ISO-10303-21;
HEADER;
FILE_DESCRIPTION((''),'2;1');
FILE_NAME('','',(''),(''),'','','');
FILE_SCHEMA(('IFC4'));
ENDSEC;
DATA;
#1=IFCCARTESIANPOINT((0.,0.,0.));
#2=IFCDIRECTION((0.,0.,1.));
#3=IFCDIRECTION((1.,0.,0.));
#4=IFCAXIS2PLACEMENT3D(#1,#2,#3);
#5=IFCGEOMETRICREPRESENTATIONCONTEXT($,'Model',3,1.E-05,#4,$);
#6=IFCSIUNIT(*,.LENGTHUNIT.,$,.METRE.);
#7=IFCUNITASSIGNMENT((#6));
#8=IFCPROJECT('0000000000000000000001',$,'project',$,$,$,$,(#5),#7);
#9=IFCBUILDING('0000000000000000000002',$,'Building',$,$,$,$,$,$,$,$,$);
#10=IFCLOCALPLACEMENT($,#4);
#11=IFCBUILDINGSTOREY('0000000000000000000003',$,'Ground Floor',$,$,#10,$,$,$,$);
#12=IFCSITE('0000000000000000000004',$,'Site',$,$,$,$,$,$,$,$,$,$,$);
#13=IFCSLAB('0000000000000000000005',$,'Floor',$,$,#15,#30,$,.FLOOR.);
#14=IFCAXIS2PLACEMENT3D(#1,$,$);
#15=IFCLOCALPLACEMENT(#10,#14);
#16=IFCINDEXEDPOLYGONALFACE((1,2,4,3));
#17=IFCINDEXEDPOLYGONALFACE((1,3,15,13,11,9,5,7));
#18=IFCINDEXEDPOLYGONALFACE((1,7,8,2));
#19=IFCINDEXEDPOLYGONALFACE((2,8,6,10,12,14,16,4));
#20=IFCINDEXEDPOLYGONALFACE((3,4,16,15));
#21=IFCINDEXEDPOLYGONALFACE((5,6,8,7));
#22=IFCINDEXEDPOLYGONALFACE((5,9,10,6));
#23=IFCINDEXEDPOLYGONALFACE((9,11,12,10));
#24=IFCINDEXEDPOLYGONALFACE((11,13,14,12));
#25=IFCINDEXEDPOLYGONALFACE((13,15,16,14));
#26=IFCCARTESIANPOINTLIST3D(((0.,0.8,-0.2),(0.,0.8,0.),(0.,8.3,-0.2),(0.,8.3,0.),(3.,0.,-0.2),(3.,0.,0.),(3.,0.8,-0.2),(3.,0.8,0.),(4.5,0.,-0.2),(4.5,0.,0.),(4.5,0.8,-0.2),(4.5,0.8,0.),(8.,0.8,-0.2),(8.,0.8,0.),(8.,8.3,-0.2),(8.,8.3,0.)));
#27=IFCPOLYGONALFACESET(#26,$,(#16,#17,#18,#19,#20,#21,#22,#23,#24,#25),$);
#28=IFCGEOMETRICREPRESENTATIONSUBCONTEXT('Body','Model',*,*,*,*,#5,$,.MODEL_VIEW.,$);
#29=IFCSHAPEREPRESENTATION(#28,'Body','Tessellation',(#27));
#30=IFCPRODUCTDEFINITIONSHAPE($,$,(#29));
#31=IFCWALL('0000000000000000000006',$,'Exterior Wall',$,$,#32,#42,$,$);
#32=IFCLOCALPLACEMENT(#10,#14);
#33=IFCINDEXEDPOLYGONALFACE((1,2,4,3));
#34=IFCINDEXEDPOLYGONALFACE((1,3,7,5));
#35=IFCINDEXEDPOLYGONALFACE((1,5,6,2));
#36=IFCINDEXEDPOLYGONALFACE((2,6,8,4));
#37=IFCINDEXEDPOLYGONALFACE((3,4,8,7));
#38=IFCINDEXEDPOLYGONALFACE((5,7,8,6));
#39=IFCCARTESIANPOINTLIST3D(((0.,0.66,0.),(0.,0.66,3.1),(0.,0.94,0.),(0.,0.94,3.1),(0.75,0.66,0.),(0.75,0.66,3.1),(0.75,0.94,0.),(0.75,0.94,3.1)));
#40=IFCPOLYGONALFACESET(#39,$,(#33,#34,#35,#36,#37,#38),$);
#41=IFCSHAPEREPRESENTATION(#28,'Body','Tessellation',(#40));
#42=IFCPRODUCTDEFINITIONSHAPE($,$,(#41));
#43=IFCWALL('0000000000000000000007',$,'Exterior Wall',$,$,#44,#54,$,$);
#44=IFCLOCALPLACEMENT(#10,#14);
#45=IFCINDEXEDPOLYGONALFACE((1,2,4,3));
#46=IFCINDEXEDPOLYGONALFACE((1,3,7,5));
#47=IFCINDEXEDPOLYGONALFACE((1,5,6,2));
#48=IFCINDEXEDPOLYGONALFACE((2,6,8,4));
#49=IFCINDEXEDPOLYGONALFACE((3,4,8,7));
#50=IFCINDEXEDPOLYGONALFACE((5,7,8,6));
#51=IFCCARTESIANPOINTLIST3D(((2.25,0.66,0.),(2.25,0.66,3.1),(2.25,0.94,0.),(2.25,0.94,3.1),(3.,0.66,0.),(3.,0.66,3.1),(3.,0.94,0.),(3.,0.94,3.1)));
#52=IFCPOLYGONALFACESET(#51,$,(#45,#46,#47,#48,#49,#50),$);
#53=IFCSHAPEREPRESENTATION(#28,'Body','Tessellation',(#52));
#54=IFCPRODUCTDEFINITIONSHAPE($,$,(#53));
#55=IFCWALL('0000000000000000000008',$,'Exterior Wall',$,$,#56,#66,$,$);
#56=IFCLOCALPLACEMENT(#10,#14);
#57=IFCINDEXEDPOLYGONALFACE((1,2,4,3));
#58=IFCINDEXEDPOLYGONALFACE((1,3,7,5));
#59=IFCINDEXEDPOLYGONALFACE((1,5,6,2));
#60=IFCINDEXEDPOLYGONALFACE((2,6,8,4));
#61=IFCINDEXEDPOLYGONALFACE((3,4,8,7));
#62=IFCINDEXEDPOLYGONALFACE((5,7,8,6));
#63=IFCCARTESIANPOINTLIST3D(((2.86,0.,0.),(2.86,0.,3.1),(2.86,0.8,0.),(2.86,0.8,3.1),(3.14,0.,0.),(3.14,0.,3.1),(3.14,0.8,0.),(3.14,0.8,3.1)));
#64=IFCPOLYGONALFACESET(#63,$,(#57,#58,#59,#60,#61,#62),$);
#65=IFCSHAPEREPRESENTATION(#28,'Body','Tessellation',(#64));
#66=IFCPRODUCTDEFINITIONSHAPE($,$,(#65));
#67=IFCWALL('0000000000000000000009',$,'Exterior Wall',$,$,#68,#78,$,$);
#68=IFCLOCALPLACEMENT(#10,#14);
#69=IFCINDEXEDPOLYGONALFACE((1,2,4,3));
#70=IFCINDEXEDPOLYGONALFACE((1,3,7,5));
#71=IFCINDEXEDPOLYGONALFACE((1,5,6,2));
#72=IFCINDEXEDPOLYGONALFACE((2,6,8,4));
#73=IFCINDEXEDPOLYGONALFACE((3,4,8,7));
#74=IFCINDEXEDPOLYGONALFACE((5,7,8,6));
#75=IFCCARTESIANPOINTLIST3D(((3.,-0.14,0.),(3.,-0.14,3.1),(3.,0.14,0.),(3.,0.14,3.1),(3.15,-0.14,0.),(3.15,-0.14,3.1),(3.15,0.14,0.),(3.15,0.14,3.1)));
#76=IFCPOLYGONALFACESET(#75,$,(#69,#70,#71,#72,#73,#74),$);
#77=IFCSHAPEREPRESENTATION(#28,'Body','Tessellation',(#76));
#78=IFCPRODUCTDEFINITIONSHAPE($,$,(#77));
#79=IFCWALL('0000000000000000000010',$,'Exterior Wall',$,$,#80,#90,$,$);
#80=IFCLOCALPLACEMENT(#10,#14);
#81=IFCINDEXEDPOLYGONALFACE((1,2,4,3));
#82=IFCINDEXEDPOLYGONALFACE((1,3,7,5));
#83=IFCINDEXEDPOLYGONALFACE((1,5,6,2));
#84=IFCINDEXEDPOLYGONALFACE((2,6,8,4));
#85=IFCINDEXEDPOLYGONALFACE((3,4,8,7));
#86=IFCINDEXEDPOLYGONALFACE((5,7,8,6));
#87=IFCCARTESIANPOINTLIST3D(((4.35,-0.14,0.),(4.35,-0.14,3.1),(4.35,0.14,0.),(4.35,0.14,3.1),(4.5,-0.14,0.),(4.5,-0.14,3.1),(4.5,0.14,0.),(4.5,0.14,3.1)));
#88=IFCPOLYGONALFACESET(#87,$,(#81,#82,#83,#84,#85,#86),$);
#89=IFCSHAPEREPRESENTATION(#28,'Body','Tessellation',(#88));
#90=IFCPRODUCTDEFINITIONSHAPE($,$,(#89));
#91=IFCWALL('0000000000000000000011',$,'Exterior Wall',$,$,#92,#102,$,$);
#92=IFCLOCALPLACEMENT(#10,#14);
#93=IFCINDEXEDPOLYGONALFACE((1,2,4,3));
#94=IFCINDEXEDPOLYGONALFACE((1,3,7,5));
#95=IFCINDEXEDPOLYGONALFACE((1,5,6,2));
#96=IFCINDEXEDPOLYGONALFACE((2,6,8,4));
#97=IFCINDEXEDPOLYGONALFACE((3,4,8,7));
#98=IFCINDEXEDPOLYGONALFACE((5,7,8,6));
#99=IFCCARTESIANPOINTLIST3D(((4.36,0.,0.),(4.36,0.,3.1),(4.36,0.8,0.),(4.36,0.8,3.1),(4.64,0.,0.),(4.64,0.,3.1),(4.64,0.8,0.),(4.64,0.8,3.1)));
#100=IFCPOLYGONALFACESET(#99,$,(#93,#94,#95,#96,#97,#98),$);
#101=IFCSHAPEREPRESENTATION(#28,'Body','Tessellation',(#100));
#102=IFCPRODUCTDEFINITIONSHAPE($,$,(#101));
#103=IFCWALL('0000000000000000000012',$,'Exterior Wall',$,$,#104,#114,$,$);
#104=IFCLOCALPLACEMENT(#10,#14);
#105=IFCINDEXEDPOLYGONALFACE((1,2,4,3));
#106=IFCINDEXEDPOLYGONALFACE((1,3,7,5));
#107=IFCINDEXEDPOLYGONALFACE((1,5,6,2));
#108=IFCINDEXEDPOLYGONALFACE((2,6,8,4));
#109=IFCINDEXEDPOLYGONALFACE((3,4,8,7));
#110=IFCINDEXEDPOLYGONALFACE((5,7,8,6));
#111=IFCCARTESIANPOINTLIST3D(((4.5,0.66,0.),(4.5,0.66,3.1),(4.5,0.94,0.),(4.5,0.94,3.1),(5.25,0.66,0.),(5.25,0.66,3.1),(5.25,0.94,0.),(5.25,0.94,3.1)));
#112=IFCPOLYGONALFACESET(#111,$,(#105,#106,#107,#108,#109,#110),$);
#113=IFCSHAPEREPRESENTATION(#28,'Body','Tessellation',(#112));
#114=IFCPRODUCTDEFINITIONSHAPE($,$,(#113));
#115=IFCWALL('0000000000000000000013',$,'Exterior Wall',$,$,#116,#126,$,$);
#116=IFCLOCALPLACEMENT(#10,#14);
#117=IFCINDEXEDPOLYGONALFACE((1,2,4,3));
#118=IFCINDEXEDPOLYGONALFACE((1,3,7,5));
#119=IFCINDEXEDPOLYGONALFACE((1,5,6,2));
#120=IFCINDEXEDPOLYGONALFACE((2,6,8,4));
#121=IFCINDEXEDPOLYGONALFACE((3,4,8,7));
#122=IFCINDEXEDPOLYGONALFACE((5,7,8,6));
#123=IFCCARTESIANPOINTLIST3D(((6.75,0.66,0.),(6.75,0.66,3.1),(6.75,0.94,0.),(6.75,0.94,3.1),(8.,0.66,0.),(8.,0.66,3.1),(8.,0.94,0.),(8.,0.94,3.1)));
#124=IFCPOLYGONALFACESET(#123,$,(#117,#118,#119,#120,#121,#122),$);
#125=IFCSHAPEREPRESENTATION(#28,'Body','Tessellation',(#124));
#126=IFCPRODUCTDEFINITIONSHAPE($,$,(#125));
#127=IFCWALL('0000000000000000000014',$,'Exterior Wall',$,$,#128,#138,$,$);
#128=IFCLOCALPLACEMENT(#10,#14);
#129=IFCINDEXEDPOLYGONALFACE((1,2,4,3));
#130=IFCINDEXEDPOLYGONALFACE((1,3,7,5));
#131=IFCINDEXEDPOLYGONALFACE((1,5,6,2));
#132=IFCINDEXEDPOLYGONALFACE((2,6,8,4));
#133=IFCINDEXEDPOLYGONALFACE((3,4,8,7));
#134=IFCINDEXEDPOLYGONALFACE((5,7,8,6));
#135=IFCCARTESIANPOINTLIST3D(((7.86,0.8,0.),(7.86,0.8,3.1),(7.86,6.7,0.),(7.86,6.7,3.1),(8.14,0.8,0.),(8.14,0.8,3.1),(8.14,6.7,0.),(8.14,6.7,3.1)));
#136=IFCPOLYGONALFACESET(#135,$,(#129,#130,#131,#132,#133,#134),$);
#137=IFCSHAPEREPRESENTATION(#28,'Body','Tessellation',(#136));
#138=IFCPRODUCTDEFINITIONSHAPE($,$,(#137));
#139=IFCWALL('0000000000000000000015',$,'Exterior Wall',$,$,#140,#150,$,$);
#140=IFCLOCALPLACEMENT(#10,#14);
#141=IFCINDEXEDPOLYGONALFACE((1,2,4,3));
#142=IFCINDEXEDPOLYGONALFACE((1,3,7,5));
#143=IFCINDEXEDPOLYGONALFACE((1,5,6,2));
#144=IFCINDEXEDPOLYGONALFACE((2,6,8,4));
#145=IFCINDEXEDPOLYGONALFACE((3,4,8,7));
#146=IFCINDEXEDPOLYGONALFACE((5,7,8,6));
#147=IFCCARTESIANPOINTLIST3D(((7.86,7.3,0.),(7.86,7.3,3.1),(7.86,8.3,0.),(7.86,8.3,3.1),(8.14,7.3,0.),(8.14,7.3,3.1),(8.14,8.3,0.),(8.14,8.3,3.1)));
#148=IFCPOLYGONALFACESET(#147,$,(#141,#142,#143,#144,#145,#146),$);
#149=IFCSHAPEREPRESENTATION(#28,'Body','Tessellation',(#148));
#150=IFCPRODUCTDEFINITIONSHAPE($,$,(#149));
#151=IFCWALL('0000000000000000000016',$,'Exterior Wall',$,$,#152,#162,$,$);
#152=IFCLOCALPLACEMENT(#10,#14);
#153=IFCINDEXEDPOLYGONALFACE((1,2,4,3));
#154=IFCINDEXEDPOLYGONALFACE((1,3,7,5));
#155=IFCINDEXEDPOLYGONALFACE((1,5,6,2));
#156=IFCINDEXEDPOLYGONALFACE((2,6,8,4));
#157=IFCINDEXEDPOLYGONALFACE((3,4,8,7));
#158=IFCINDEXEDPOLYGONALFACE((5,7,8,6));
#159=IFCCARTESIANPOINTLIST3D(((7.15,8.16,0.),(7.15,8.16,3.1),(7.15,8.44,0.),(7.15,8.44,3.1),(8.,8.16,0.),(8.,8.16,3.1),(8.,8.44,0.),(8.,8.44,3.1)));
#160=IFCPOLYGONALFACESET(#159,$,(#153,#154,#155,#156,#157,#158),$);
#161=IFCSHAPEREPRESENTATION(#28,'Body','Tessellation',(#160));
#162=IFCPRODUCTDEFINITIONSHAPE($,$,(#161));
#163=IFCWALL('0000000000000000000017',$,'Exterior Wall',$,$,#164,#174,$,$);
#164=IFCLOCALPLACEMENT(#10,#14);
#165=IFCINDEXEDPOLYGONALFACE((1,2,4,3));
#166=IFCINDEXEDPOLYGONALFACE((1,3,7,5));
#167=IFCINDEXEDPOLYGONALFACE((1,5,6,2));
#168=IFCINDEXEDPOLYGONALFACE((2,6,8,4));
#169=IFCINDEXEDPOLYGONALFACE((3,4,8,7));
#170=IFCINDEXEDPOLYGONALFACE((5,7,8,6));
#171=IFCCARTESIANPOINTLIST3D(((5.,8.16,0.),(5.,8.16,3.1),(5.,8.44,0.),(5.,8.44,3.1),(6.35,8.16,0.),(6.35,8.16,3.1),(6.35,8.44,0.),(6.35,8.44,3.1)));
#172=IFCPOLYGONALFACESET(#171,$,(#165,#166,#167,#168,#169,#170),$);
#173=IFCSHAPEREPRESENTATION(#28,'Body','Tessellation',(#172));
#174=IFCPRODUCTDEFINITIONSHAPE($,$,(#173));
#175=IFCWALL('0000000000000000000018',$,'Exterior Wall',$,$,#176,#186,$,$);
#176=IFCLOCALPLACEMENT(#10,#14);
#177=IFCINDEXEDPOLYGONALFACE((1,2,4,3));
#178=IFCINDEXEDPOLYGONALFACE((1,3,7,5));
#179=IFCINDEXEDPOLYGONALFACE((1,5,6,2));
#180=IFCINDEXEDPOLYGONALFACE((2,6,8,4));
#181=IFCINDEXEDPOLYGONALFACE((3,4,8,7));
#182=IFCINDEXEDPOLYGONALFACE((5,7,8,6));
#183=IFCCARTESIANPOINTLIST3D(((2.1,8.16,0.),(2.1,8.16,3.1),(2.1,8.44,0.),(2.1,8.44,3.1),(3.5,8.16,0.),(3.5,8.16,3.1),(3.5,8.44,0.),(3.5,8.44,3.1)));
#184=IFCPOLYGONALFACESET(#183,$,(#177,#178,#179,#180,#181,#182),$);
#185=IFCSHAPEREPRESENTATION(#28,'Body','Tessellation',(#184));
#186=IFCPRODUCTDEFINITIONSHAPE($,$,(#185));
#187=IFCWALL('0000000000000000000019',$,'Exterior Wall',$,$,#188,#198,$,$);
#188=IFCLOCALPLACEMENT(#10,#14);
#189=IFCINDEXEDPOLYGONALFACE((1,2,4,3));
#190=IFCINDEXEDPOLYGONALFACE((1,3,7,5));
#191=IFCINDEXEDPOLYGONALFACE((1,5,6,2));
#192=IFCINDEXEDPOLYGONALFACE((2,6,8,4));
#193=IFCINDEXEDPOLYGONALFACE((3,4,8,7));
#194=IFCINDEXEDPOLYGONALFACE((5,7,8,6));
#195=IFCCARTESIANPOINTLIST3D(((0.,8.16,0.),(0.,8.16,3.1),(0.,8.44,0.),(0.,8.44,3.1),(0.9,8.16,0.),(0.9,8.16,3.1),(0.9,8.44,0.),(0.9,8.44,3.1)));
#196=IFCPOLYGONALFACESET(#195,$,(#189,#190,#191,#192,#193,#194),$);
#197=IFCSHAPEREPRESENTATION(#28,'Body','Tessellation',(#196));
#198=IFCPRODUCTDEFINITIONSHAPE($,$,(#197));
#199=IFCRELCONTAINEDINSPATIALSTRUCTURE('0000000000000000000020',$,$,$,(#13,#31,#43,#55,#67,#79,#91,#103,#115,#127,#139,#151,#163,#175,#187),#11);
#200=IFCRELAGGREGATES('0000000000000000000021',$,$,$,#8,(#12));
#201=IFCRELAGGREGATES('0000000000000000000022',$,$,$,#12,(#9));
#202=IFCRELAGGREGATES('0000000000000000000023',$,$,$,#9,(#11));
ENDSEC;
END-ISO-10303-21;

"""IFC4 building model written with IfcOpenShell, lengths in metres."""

from ifc_helpers import new_model, si_unit, frame, origin_with_axes, place, context, subcontext, project, spatial, indexed_curve, outline, extrude, element, save


model = new_model("IFC4")

# Units and contexts
model_context = context("Model", 3, precision=1e-05, world=origin_with_axes())
body_context = subcontext(model_context, "Body", "Model", "MODEL_VIEW")
ifc_project = project(units=[si_unit("LENGTHUNIT", "METRE")], contexts=[model_context])

# Site, building, storey
site = spatial("IfcSite", under=ifc_project, Name="Site")
building = spatial("IfcBuilding", under=site, Name="Building")
storey_placement = place(None, origin_with_axes())
storey = spatial("IfcBuildingStorey", under=building, at=storey_placement, Name="Ground Floor")

# Slab
slab_placement = place(storey_placement, frame((0.0, 0.0, -0.2), z_axis=(0.0, 0.0, 1.0), x_axis=(1.0, 0.0, 0.0)))
element("IfcSlab", 1, at=slab_placement, inside=storey, Name="Floor", PredefinedType="FLOOR", context=body_context, shape_type="SweptSolid", body=[
    extrude(outline(indexed_curve([(0.0, 0.8), (3.0, 0.8), (3.0, 0.0), (4.5, 0.0), (4.5, 0.8), (8.0, 0.8), (8.0, 8.3), (0.0, 8.3)])), None, (0.0, 0.0, 1.0), 0.2),
])

# Walls
for number, where, z_axis, x_axis, name in (
    (2, (0.0, 0.8, 0.0), (0.0, 0.0, 1.0), (1.0, 0.0, 0.0), "Exterior Wall"),
    (3, (2.25, 0.8, 0.0), (0.0, 0.0, 1.0), (1.0, 0.0, 0.0), "Exterior Wall"),
):
    element("IfcWall", number, at=place(storey_placement, frame(where, z_axis=z_axis, x_axis=x_axis)), inside=storey, Name=name, context=body_context, shape_type="SweptSolid", body=[
        extrude(outline(indexed_curve([(0.0, 0.0), (0.0, 0.28), (0.75, 0.28), (0.75, 0.0), (0.0, 0.0)], self_intersect=False)), frame((0.0, -0.14, 0.0), z_axis=(0.0, 0.0, 1.0), x_axis=(1.0, 0.0, 0.0)), (0.0, 0.0, 1.0), 3.1),
    ])
wall_1_placement = place(storey_placement, frame((3.0, 0.8, 0.0), z_axis=(0.0, 0.0, 1.0), x_axis=(0.0, -1.0, 0.0)))
element("IfcWall", 4, at=wall_1_placement, inside=storey, Name="Exterior Wall", context=body_context, shape_type="SweptSolid", body=[
    extrude(outline(indexed_curve([(0.0, 0.0), (0.0, 0.28), (0.8, 0.28), (0.8, 0.0), (0.0, 0.0)], self_intersect=False)), frame((0.0, -0.14, 0.0), z_axis=(0.0, 0.0, 1.0), x_axis=(1.0, 0.0, 0.0)), (0.0, 0.0, 1.0), 3.1),
])
wall_2_placement = place(storey_placement, frame((3.0, 0.0, 0.0), z_axis=(0.0, 0.0, 1.0), x_axis=(1.0, 0.0, 0.0)))
element("IfcWall", 5, at=wall_2_placement, inside=storey, Name="Exterior Wall", context=body_context, shape_type="SweptSolid", body=[
    extrude(outline(indexed_curve([(0.0, 0.0), (0.0, 0.28), (0.15, 0.28), (0.15, 0.0), (0.0, 0.0)], self_intersect=False)), frame((0.0, -0.14, 0.0), z_axis=(0.0, 0.0, 1.0), x_axis=(1.0, 0.0, 0.0)), (0.0, 0.0, 1.0), 3.1),
])
wall_3_placement = place(storey_placement, frame((4.35, 0.0, 0.0), z_axis=(0.0, 0.0, 1.0), x_axis=(1.0, 0.0, 0.0)))
element("IfcWall", 6, at=wall_3_placement, inside=storey, Name="Exterior Wall", context=body_context, shape_type="SweptSolid", body=[
    extrude(outline(indexed_curve([(0.0, 0.0), (0.0, 0.28), (0.15, 0.28), (0.15, 0.0), (0.0, 0.0)], self_intersect=False)), frame((0.0, -0.14, 0.0), z_axis=(0.0, 0.0, 1.0), x_axis=(1.0, 0.0, 0.0)), (0.0, 0.0, 1.0), 3.1),
])
wall_4_placement = place(storey_placement, frame((4.5, 0.0, 0.0), z_axis=(0.0, 0.0, 1.0), x_axis=(0.0, 1.0, 0.0)))
element("IfcWall", 7, at=wall_4_placement, inside=storey, Name="Exterior Wall", context=body_context, shape_type="SweptSolid", body=[
    extrude(outline(indexed_curve([(0.0, 0.0), (0.0, 0.28), (0.8, 0.28), (0.8, 0.0), (0.0, 0.0)], self_intersect=False)), frame((0.0, -0.14, 0.0), z_axis=(0.0, 0.0, 1.0), x_axis=(1.0, 0.0, 0.0)), (0.0, 0.0, 1.0), 3.1),
])
wall_5_placement = place(storey_placement, frame((4.5, 0.8, 0.0), z_axis=(0.0, 0.0, 1.0), x_axis=(1.0, 0.0, 0.0)))
element("IfcWall", 8, at=wall_5_placement, inside=storey, Name="Exterior Wall", context=body_context, shape_type="SweptSolid", body=[
    extrude(outline(indexed_curve([(0.0, 0.0), (0.0, 0.28), (0.75, 0.28), (0.75, 0.0), (0.0, 0.0)], self_intersect=False)), frame((0.0, -0.14, 0.0), z_axis=(0.0, 0.0, 1.0), x_axis=(1.0, 0.0, 0.0)), (0.0, 0.0, 1.0), 3.1),
])
wall_6_placement = place(storey_placement, frame((6.75, 0.8, 0.0), z_axis=(0.0, 0.0, 1.0), x_axis=(1.0, 0.0, 0.0)))
element("IfcWall", 9, at=wall_6_placement, inside=storey, Name="Exterior Wall", context=body_context, shape_type="SweptSolid", body=[
    extrude(outline(indexed_curve([(0.0, 0.0), (0.0, 0.28), (1.25, 0.28), (1.25, 0.0), (0.0, 0.0)], self_intersect=False)), frame((0.0, -0.14, 0.0), z_axis=(0.0, 0.0, 1.0), x_axis=(1.0, 0.0, 0.0)), (0.0, 0.0, 1.0), 3.1),
])
wall_7_placement = place(storey_placement, frame((8.0, 0.8, 0.0), z_axis=(0.0, 0.0, 1.0), x_axis=(0.0, 1.0, 0.0)))
element("IfcWall", 10, at=wall_7_placement, inside=storey, Name="Exterior Wall", context=body_context, shape_type="SweptSolid", body=[
    extrude(outline(indexed_curve([(0.0, 0.0), (0.0, 0.28), (5.9, 0.28), (5.9, 0.0), (0.0, 0.0)], self_intersect=False)), frame((0.0, -0.14, 0.0), z_axis=(0.0, 0.0, 1.0), x_axis=(1.0, 0.0, 0.0)), (0.0, 0.0, 1.0), 3.1),
])
wall_8_placement = place(storey_placement, frame((8.0, 7.3, 0.0), z_axis=(0.0, 0.0, 1.0), x_axis=(0.0, 1.0, 0.0)))
element("IfcWall", 11, at=wall_8_placement, inside=storey, Name="Exterior Wall", context=body_context, shape_type="SweptSolid", body=[
    extrude(outline(indexed_curve([(0.0, 0.0), (0.0, 0.28), (1.0, 0.28), (1.0, 0.0), (0.0, 0.0)], self_intersect=False)), frame((0.0, -0.14, 0.0), z_axis=(0.0, 0.0, 1.0), x_axis=(1.0, 0.0, 0.0)), (0.0, 0.0, 1.0), 3.1),
])
wall_9_placement = place(storey_placement, frame((8.0, 8.3, 0.0), z_axis=(0.0, 0.0, 1.0), x_axis=(-1.0, 0.0, 0.0)))
element("IfcWall", 12, at=wall_9_placement, inside=storey, Name="Exterior Wall", context=body_context, shape_type="SweptSolid", body=[
    extrude(outline(indexed_curve([(0.0, 0.0), (0.0, 0.28), (0.85, 0.28), (0.85, 0.0), (0.0, 0.0)], self_intersect=False)), frame((0.0, -0.14, 0.0), z_axis=(0.0, 0.0, 1.0), x_axis=(1.0, 0.0, 0.0)), (0.0, 0.0, 1.0), 3.1),
])
wall_10_placement = place(storey_placement, frame((6.35, 8.3, 0.0), z_axis=(0.0, 0.0, 1.0), x_axis=(-1.0, 0.0, 0.0)))
element("IfcWall", 13, at=wall_10_placement, inside=storey, Name="Exterior Wall", context=body_context, shape_type="SweptSolid", body=[
    extrude(outline(indexed_curve([(0.0, 0.0), (0.0, 0.28), (1.35, 0.28), (1.35, 0.0), (0.0, 0.0)], self_intersect=False)), frame((0.0, -0.14, 0.0), z_axis=(0.0, 0.0, 1.0), x_axis=(1.0, 0.0, 0.0)), (0.0, 0.0, 1.0), 3.1),
])
wall_11_placement = place(storey_placement, frame((3.5, 8.3, 0.0), z_axis=(0.0, 0.0, 1.0), x_axis=(-1.0, 0.0, 0.0)))
element("IfcWall", 14, at=wall_11_placement, inside=storey, Name="Exterior Wall", context=body_context, shape_type="SweptSolid", body=[
    extrude(outline(indexed_curve([(0.0, 0.0), (0.0, 0.28), (1.4, 0.28), (1.4, 0.0), (0.0, 0.0)], self_intersect=False)), frame((0.0, -0.14, 0.0), z_axis=(0.0, 0.0, 1.0), x_axis=(1.0, 0.0, 0.0)), (0.0, 0.0, 1.0), 3.1),
])
wall_12_placement = place(storey_placement, frame((0.9, 8.3, 0.0), z_axis=(0.0, 0.0, 1.0), x_axis=(-1.0, 0.0, 0.0)))
element("IfcWall", 15, at=wall_12_placement, inside=storey, Name="Exterior Wall", context=body_context, shape_type="SweptSolid", body=[
    extrude(outline(indexed_curve([(0.0, 0.0), (0.0, 0.28), (0.9, 0.28), (0.9, 0.0), (0.0, 0.0)], self_intersect=False)), frame((0.0, -0.14, 0.0), z_axis=(0.0, 0.0, 1.0), x_axis=(1.0, 0.0, 0.0)), (0.0, 0.0, 1.0), 3.1),
])

save(model, "model.ifc")
